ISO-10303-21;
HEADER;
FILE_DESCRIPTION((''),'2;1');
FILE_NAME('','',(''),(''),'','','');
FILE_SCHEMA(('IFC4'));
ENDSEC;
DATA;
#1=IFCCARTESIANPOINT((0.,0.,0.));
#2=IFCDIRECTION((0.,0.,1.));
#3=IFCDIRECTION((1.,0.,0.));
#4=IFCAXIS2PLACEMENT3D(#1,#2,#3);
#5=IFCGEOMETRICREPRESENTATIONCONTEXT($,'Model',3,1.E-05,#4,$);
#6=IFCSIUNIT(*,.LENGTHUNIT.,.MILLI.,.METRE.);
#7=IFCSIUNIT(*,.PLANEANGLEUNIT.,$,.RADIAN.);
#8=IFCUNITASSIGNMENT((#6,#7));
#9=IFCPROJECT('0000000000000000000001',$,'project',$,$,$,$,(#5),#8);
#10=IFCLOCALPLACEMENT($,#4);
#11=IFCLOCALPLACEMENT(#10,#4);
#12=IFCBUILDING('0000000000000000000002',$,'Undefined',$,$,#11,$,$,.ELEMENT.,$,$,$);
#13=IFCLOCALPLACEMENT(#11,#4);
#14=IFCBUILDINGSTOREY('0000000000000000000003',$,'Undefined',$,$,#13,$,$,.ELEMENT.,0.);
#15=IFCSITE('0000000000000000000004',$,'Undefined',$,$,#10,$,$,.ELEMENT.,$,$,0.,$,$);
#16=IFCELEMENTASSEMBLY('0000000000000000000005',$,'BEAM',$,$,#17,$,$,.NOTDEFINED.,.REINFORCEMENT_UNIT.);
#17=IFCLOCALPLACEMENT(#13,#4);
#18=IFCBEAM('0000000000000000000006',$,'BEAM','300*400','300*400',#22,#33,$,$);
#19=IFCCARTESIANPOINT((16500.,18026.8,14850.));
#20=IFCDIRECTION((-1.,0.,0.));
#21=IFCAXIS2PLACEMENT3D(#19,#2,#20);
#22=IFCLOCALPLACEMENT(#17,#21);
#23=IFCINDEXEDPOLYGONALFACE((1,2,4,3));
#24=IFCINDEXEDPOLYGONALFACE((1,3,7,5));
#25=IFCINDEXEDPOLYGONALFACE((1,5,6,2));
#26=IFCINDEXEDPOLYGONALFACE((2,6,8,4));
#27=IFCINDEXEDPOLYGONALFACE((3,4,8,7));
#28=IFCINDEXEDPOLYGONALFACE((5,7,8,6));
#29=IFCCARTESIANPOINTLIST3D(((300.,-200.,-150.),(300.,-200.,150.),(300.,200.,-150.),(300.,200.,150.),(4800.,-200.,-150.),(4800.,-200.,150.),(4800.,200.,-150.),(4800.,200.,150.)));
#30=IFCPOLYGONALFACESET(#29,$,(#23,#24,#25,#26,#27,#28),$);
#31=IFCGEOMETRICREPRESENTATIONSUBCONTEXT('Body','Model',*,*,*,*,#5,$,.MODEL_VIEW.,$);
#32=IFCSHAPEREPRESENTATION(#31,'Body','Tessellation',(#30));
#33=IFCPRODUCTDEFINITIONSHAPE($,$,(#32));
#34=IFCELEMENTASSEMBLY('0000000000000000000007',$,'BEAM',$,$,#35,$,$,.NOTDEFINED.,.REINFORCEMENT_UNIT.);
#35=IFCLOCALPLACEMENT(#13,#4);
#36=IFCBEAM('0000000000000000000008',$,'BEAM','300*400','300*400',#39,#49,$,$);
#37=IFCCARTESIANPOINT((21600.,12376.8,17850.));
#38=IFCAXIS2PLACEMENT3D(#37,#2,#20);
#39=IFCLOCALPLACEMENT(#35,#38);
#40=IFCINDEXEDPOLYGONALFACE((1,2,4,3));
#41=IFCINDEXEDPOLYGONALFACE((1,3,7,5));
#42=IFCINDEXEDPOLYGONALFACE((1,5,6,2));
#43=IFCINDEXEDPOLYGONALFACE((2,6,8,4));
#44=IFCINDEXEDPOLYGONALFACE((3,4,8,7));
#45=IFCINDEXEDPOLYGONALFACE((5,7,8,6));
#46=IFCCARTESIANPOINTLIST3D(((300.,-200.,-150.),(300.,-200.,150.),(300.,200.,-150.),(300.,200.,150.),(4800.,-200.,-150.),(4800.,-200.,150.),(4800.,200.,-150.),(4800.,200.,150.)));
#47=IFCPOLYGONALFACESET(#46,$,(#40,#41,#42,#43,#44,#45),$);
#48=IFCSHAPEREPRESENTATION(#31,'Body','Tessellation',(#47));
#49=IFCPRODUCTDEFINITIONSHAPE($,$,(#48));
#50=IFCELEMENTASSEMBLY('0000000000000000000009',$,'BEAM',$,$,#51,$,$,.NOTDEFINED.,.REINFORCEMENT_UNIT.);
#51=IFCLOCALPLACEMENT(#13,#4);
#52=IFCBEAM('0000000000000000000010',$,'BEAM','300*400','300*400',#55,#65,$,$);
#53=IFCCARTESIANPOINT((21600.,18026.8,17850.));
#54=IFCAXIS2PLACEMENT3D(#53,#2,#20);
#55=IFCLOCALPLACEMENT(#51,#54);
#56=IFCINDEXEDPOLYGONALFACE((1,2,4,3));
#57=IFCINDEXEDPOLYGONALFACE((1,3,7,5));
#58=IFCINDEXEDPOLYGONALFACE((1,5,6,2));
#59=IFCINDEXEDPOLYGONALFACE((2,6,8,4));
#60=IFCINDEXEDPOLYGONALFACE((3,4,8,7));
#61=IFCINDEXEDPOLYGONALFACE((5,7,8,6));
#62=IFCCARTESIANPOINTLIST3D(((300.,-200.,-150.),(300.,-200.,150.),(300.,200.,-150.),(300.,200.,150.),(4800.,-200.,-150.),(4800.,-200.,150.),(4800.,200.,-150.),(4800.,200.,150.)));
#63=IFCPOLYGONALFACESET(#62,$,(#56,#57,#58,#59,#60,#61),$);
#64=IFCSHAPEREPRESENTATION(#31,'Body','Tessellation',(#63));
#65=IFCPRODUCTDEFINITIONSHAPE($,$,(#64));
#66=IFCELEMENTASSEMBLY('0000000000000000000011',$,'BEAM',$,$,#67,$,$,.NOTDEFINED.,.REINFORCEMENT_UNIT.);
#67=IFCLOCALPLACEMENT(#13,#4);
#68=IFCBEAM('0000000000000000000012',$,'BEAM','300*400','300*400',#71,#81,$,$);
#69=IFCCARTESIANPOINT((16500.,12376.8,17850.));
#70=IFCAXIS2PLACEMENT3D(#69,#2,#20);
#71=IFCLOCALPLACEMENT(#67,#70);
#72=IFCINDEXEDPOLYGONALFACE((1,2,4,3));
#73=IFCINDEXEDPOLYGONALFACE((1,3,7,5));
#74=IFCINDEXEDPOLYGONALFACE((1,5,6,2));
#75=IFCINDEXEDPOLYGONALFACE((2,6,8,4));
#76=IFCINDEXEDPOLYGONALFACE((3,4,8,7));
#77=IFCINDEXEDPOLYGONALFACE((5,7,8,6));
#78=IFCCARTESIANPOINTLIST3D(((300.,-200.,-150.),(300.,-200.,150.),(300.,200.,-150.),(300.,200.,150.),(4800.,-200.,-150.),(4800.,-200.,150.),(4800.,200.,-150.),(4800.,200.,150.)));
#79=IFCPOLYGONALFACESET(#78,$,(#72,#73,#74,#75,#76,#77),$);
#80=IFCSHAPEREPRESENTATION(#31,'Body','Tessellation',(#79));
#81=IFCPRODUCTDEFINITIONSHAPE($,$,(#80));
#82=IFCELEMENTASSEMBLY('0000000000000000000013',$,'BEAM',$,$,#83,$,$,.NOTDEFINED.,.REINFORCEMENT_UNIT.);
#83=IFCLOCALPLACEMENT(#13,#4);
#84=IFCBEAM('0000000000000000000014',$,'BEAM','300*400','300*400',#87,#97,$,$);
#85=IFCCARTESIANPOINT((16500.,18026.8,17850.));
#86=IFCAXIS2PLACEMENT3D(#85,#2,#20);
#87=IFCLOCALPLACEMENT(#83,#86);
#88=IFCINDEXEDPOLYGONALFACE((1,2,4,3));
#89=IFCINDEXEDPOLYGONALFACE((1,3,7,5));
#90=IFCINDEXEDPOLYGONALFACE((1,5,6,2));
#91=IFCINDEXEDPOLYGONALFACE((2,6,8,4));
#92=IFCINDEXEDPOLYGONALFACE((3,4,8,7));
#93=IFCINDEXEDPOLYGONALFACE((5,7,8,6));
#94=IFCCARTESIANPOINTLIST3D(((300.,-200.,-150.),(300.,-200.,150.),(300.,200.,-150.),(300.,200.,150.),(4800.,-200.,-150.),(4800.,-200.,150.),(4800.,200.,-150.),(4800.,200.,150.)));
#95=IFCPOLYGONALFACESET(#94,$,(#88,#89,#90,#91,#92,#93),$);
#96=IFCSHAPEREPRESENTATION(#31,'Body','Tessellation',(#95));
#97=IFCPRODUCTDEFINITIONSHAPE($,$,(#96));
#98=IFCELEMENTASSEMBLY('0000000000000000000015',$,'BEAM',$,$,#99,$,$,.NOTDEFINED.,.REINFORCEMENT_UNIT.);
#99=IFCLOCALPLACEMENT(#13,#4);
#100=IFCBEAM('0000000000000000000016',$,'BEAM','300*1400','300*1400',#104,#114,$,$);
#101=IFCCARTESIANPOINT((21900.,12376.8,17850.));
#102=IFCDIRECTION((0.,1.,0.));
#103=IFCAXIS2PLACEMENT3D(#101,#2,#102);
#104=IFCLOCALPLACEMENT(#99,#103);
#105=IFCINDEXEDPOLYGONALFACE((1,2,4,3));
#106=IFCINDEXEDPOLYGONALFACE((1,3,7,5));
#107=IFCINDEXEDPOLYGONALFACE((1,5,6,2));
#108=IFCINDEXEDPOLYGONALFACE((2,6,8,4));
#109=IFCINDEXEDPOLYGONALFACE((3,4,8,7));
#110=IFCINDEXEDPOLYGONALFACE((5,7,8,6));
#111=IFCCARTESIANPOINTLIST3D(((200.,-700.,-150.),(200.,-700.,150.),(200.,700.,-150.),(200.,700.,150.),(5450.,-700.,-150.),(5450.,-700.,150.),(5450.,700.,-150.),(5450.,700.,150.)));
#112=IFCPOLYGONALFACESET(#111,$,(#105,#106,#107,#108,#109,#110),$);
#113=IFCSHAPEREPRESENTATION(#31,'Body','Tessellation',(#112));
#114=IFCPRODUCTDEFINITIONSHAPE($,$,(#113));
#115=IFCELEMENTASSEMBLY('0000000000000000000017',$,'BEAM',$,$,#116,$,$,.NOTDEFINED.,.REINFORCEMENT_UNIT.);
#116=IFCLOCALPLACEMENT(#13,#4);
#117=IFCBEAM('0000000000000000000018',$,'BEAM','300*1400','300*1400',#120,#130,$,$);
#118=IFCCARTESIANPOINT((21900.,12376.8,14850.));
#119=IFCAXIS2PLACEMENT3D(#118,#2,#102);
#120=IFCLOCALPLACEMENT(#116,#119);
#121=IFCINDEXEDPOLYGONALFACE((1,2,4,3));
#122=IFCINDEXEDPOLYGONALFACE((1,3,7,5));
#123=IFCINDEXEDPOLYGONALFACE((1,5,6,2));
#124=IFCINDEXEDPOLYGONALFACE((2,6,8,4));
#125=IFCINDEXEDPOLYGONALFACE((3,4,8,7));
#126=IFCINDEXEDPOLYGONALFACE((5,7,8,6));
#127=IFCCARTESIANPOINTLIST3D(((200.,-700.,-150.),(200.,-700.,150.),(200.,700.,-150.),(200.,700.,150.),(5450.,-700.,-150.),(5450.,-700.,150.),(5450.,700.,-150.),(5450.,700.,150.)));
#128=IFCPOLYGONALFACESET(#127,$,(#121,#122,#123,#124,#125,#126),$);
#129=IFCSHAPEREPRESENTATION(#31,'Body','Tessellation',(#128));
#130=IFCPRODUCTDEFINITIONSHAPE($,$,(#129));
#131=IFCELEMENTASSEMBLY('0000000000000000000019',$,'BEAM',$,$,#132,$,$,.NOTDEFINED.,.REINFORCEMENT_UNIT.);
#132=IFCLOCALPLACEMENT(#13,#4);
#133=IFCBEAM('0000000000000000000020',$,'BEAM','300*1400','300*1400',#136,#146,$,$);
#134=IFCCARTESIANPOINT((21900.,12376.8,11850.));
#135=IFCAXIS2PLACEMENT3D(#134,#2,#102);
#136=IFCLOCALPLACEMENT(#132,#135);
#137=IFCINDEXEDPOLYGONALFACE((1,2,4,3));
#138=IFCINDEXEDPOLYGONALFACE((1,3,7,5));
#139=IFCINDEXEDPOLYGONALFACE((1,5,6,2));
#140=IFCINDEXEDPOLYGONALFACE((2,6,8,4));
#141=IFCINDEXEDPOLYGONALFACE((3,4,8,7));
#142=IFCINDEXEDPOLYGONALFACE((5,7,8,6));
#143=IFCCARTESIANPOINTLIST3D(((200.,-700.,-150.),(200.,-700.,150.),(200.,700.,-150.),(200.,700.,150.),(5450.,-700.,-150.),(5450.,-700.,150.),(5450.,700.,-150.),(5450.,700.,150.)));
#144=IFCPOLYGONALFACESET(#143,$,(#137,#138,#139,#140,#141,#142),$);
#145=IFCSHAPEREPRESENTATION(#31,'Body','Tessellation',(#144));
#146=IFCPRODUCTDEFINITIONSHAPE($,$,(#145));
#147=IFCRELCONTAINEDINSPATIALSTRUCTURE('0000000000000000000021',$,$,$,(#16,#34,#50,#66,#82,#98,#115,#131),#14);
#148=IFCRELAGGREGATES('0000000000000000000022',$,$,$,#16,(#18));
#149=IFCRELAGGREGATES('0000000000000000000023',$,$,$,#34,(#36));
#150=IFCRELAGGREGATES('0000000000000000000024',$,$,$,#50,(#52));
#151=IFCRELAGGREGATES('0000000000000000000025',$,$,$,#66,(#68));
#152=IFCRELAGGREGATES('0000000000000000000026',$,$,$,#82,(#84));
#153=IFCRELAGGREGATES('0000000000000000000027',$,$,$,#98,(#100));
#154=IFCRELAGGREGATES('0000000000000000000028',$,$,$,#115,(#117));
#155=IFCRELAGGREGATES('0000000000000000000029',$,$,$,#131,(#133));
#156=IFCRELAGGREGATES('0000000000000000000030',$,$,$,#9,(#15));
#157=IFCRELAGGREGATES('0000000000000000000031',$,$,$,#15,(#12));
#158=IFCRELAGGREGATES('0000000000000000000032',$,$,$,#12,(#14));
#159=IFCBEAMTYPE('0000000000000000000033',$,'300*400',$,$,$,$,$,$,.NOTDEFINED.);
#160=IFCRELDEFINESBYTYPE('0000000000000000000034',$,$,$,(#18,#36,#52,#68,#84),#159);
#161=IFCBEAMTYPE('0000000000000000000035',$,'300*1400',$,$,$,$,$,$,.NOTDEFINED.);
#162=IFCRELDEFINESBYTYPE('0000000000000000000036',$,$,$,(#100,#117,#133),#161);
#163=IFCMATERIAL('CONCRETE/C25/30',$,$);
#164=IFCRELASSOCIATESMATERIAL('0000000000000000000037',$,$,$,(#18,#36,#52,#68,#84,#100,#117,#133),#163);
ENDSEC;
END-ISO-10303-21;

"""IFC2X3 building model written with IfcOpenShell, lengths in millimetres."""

from ifc_helpers import new_model, si_unit, frame, origin_with_axes, origin_2d_with_axis, place, context, subcontext, project, spatial, rectangle, extrude, material, type_object, element, aggregate, save


model = new_model("IFC2X3")

# Units and contexts
model_context = context("Model", 3, precision=1e-05, world=origin_with_axes())
body_context = subcontext(model_context, "Body", "Model", "MODEL_VIEW")
ifc_project = project(units=[si_unit("LENGTHUNIT", "METRE", prefix="MILLI"), si_unit("PLANEANGLEUNIT", "RADIAN")], contexts=[model_context])

# Site, building, storey
site_placement = place(None, origin_with_axes())
site = spatial("IfcSite", under=ifc_project, at=site_placement, Name="Undefined", CompositionType="ELEMENT", RefElevation=0.0)
building_placement = place(site_placement, origin_with_axes())
building = spatial("IfcBuilding", under=site, at=building_placement, Name="Undefined", CompositionType="ELEMENT")
storey_placement = place(building_placement, origin_with_axes())
storey = spatial("IfcBuildingStorey", under=building, at=storey_placement, Name="Undefined", CompositionType="ELEMENT", Elevation=0.0)

# Shared definitions
ifc_material = material(Name="CONCRETE/C25/30")

# Element assemblies, beams
beam_type_1 = type_object("IfcBeamType", Name="300*400", PredefinedType="NOTDEFINED")
assembly_1_placement = place(storey_placement, origin_with_axes())
assembly_1 = element("IfcElementAssembly", 1, at=assembly_1_placement, inside=storey, Name="BEAM", AssemblyPlace="NOTDEFINED", PredefinedType="REINFORCEMENT_UNIT")
beam_1_placement = place(assembly_1_placement, frame((16500.0, 18026.8, 14850.0), z_axis=(0.0, 0.0, 1.0), x_axis=(-1.0, 0.0, 0.0)))
beam_1 = element("IfcBeam", 2, at=beam_1_placement, type_object=beam_type_1, material=ifc_material, Name="BEAM", Description="300*400", ObjectType="300*400", context=body_context, shape_type="SweptSolid", body=[
    extrude(rectangle(XDim=400.0, YDim=300.0, at=origin_2d_with_axis()), frame((4800.0, 0.0, 0.0), z_axis=(-1.0, 0.0, 0.0), x_axis=(0.0, -1.0, 0.0)), (0.0, 0.0, 1.0), 4500.0),
])
aggregate(assembly_1, [beam_1])
assembly_2_placement = place(storey_placement, origin_with_axes())
assembly_2 = element("IfcElementAssembly", 3, at=assembly_2_placement, inside=storey, Name="BEAM", AssemblyPlace="NOTDEFINED", PredefinedType="REINFORCEMENT_UNIT")
beam_2_placement = place(assembly_2_placement, frame((21600.0, 12376.8, 17850.0), z_axis=(0.0, 0.0, 1.0), x_axis=(-1.0, 0.0, 0.0)))
beam_2 = element("IfcBeam", 4, at=beam_2_placement, type_object=beam_type_1, material=ifc_material, Name="BEAM", Description="300*400", ObjectType="300*400", context=body_context, shape_type="SweptSolid", body=[
    extrude(rectangle(XDim=400.0, YDim=300.0, at=origin_2d_with_axis()), frame((4800.0, 0.0, 0.0), z_axis=(-1.0, 0.0, 0.0), x_axis=(0.0, -1.0, 0.0)), (0.0, 0.0, 1.0), 4500.0),
])
aggregate(assembly_2, [beam_2])
assembly_3_placement = place(storey_placement, origin_with_axes())
assembly_3 = element("IfcElementAssembly", 5, at=assembly_3_placement, inside=storey, Name="BEAM", AssemblyPlace="NOTDEFINED", PredefinedType="REINFORCEMENT_UNIT")
beam_3_placement = place(assembly_3_placement, frame((21600.0, 18026.8, 17850.0), z_axis=(0.0, 0.0, 1.0), x_axis=(-1.0, 0.0, 0.0)))
beam_3 = element("IfcBeam", 6, at=beam_3_placement, type_object=beam_type_1, material=ifc_material, Name="BEAM", Description="300*400", ObjectType="300*400", context=body_context, shape_type="SweptSolid", body=[
    extrude(rectangle(XDim=400.0, YDim=300.0, at=origin_2d_with_axis()), frame((4800.0, 0.0, 0.0), z_axis=(-1.0, 0.0, 0.0), x_axis=(0.0, -1.0, 0.0)), (0.0, 0.0, 1.0), 4500.0),
])
aggregate(assembly_3, [beam_3])
assembly_4_placement = place(storey_placement, origin_with_axes())
assembly_4 = element("IfcElementAssembly", 7, at=assembly_4_placement, inside=storey, Name="BEAM", AssemblyPlace="NOTDEFINED", PredefinedType="REINFORCEMENT_UNIT")
beam_4_placement = place(assembly_4_placement, frame((16500.0, 12376.8, 17850.0), z_axis=(0.0, 0.0, 1.0), x_axis=(-1.0, 0.0, 0.0)))
beam_4 = element("IfcBeam", 8, at=beam_4_placement, type_object=beam_type_1, material=ifc_material, Name="BEAM", Description="300*400", ObjectType="300*400", context=body_context, shape_type="SweptSolid", body=[
    extrude(rectangle(XDim=400.0, YDim=300.0, at=origin_2d_with_axis()), frame((4800.0, 0.0, 0.0), z_axis=(-1.0, 0.0, 0.0), x_axis=(0.0, -1.0, 0.0)), (0.0, 0.0, 1.0), 4500.0),
])
aggregate(assembly_4, [beam_4])
assembly_5_placement = place(storey_placement, origin_with_axes())
assembly_5 = element("IfcElementAssembly", 9, at=assembly_5_placement, inside=storey, Name="BEAM", AssemblyPlace="NOTDEFINED", PredefinedType="REINFORCEMENT_UNIT")
beam_5_placement = place(assembly_5_placement, frame((16500.0, 18026.8, 17850.0), z_axis=(0.0, 0.0, 1.0), x_axis=(-1.0, 0.0, 0.0)))
beam_5 = element("IfcBeam", 10, at=beam_5_placement, type_object=beam_type_1, material=ifc_material, Name="BEAM", Description="300*400", ObjectType="300*400", context=body_context, shape_type="SweptSolid", body=[
    extrude(rectangle(XDim=400.0, YDim=300.0, at=origin_2d_with_axis()), frame((4800.0, 0.0, 0.0), z_axis=(-1.0, 0.0, 0.0), x_axis=(0.0, -1.0, 0.0)), (0.0, 0.0, 1.0), 4500.0),
])
aggregate(assembly_5, [beam_5])
assembly_6_placement = place(storey_placement, origin_with_axes())
assembly_6 = element("IfcElementAssembly", 11, at=assembly_6_placement, inside=storey, Name="BEAM", AssemblyPlace="NOTDEFINED", PredefinedType="REINFORCEMENT_UNIT")
beam_type_2 = type_object("IfcBeamType", Name="300*1400", PredefinedType="NOTDEFINED")
beam_6_placement = place(assembly_6_placement, frame((21900.0, 12376.8, 17850.0), z_axis=(0.0, 0.0, 1.0), x_axis=(0.0, 1.0, 0.0)))
beam_6 = element("IfcBeam", 12, at=beam_6_placement, type_object=beam_type_2, material=ifc_material, Name="BEAM", Description="300*1400", ObjectType="300*1400", context=body_context, shape_type="SweptSolid", body=[
    extrude(rectangle(XDim=1400.0, YDim=300.0, at=origin_2d_with_axis()), frame((5450.0, 0.0, 0.0), z_axis=(-1.0, 0.0, 0.0), x_axis=(0.0, -1.0, 0.0)), (0.0, 0.0, 1.0), 5250.0),
])
aggregate(assembly_6, [beam_6])
assembly_7_placement = place(storey_placement, origin_with_axes())
assembly_7 = element("IfcElementAssembly", 13, at=assembly_7_placement, inside=storey, Name="BEAM", AssemblyPlace="NOTDEFINED", PredefinedType="REINFORCEMENT_UNIT")
beam_7_placement = place(assembly_7_placement, frame((21900.0, 12376.8, 14850.0), z_axis=(0.0, 0.0, 1.0), x_axis=(0.0, 1.0, 0.0)))
beam_7 = element("IfcBeam", 14, at=beam_7_placement, type_object=beam_type_2, material=ifc_material, Name="BEAM", Description="300*1400", ObjectType="300*1400", context=body_context, shape_type="SweptSolid", body=[
    extrude(rectangle(XDim=1400.0, YDim=300.0, at=origin_2d_with_axis()), frame((5450.0, 0.0, 0.0), z_axis=(-1.0, 0.0, 0.0), x_axis=(0.0, -1.0, 0.0)), (0.0, 0.0, 1.0), 5250.0),
])
aggregate(assembly_7, [beam_7])
assembly_8_placement = place(storey_placement, origin_with_axes())
assembly_8 = element("IfcElementAssembly", 15, at=assembly_8_placement, inside=storey, Name="BEAM", AssemblyPlace="NOTDEFINED", PredefinedType="REINFORCEMENT_UNIT")
beam_8_placement = place(assembly_8_placement, frame((21900.0, 12376.8, 11850.0), z_axis=(0.0, 0.0, 1.0), x_axis=(0.0, 1.0, 0.0)))
beam_8 = element("IfcBeam", 16, at=beam_8_placement, type_object=beam_type_2, material=ifc_material, Name="BEAM", Description="300*1400", ObjectType="300*1400", context=body_context, shape_type="SweptSolid", body=[
    extrude(rectangle(XDim=1400.0, YDim=300.0, at=origin_2d_with_axis()), frame((5450.0, 0.0, 0.0), z_axis=(-1.0, 0.0, 0.0), x_axis=(0.0, -1.0, 0.0)), (0.0, 0.0, 1.0), 5250.0),
])
aggregate(assembly_8, [beam_8])

save(model, "model.ifc")
